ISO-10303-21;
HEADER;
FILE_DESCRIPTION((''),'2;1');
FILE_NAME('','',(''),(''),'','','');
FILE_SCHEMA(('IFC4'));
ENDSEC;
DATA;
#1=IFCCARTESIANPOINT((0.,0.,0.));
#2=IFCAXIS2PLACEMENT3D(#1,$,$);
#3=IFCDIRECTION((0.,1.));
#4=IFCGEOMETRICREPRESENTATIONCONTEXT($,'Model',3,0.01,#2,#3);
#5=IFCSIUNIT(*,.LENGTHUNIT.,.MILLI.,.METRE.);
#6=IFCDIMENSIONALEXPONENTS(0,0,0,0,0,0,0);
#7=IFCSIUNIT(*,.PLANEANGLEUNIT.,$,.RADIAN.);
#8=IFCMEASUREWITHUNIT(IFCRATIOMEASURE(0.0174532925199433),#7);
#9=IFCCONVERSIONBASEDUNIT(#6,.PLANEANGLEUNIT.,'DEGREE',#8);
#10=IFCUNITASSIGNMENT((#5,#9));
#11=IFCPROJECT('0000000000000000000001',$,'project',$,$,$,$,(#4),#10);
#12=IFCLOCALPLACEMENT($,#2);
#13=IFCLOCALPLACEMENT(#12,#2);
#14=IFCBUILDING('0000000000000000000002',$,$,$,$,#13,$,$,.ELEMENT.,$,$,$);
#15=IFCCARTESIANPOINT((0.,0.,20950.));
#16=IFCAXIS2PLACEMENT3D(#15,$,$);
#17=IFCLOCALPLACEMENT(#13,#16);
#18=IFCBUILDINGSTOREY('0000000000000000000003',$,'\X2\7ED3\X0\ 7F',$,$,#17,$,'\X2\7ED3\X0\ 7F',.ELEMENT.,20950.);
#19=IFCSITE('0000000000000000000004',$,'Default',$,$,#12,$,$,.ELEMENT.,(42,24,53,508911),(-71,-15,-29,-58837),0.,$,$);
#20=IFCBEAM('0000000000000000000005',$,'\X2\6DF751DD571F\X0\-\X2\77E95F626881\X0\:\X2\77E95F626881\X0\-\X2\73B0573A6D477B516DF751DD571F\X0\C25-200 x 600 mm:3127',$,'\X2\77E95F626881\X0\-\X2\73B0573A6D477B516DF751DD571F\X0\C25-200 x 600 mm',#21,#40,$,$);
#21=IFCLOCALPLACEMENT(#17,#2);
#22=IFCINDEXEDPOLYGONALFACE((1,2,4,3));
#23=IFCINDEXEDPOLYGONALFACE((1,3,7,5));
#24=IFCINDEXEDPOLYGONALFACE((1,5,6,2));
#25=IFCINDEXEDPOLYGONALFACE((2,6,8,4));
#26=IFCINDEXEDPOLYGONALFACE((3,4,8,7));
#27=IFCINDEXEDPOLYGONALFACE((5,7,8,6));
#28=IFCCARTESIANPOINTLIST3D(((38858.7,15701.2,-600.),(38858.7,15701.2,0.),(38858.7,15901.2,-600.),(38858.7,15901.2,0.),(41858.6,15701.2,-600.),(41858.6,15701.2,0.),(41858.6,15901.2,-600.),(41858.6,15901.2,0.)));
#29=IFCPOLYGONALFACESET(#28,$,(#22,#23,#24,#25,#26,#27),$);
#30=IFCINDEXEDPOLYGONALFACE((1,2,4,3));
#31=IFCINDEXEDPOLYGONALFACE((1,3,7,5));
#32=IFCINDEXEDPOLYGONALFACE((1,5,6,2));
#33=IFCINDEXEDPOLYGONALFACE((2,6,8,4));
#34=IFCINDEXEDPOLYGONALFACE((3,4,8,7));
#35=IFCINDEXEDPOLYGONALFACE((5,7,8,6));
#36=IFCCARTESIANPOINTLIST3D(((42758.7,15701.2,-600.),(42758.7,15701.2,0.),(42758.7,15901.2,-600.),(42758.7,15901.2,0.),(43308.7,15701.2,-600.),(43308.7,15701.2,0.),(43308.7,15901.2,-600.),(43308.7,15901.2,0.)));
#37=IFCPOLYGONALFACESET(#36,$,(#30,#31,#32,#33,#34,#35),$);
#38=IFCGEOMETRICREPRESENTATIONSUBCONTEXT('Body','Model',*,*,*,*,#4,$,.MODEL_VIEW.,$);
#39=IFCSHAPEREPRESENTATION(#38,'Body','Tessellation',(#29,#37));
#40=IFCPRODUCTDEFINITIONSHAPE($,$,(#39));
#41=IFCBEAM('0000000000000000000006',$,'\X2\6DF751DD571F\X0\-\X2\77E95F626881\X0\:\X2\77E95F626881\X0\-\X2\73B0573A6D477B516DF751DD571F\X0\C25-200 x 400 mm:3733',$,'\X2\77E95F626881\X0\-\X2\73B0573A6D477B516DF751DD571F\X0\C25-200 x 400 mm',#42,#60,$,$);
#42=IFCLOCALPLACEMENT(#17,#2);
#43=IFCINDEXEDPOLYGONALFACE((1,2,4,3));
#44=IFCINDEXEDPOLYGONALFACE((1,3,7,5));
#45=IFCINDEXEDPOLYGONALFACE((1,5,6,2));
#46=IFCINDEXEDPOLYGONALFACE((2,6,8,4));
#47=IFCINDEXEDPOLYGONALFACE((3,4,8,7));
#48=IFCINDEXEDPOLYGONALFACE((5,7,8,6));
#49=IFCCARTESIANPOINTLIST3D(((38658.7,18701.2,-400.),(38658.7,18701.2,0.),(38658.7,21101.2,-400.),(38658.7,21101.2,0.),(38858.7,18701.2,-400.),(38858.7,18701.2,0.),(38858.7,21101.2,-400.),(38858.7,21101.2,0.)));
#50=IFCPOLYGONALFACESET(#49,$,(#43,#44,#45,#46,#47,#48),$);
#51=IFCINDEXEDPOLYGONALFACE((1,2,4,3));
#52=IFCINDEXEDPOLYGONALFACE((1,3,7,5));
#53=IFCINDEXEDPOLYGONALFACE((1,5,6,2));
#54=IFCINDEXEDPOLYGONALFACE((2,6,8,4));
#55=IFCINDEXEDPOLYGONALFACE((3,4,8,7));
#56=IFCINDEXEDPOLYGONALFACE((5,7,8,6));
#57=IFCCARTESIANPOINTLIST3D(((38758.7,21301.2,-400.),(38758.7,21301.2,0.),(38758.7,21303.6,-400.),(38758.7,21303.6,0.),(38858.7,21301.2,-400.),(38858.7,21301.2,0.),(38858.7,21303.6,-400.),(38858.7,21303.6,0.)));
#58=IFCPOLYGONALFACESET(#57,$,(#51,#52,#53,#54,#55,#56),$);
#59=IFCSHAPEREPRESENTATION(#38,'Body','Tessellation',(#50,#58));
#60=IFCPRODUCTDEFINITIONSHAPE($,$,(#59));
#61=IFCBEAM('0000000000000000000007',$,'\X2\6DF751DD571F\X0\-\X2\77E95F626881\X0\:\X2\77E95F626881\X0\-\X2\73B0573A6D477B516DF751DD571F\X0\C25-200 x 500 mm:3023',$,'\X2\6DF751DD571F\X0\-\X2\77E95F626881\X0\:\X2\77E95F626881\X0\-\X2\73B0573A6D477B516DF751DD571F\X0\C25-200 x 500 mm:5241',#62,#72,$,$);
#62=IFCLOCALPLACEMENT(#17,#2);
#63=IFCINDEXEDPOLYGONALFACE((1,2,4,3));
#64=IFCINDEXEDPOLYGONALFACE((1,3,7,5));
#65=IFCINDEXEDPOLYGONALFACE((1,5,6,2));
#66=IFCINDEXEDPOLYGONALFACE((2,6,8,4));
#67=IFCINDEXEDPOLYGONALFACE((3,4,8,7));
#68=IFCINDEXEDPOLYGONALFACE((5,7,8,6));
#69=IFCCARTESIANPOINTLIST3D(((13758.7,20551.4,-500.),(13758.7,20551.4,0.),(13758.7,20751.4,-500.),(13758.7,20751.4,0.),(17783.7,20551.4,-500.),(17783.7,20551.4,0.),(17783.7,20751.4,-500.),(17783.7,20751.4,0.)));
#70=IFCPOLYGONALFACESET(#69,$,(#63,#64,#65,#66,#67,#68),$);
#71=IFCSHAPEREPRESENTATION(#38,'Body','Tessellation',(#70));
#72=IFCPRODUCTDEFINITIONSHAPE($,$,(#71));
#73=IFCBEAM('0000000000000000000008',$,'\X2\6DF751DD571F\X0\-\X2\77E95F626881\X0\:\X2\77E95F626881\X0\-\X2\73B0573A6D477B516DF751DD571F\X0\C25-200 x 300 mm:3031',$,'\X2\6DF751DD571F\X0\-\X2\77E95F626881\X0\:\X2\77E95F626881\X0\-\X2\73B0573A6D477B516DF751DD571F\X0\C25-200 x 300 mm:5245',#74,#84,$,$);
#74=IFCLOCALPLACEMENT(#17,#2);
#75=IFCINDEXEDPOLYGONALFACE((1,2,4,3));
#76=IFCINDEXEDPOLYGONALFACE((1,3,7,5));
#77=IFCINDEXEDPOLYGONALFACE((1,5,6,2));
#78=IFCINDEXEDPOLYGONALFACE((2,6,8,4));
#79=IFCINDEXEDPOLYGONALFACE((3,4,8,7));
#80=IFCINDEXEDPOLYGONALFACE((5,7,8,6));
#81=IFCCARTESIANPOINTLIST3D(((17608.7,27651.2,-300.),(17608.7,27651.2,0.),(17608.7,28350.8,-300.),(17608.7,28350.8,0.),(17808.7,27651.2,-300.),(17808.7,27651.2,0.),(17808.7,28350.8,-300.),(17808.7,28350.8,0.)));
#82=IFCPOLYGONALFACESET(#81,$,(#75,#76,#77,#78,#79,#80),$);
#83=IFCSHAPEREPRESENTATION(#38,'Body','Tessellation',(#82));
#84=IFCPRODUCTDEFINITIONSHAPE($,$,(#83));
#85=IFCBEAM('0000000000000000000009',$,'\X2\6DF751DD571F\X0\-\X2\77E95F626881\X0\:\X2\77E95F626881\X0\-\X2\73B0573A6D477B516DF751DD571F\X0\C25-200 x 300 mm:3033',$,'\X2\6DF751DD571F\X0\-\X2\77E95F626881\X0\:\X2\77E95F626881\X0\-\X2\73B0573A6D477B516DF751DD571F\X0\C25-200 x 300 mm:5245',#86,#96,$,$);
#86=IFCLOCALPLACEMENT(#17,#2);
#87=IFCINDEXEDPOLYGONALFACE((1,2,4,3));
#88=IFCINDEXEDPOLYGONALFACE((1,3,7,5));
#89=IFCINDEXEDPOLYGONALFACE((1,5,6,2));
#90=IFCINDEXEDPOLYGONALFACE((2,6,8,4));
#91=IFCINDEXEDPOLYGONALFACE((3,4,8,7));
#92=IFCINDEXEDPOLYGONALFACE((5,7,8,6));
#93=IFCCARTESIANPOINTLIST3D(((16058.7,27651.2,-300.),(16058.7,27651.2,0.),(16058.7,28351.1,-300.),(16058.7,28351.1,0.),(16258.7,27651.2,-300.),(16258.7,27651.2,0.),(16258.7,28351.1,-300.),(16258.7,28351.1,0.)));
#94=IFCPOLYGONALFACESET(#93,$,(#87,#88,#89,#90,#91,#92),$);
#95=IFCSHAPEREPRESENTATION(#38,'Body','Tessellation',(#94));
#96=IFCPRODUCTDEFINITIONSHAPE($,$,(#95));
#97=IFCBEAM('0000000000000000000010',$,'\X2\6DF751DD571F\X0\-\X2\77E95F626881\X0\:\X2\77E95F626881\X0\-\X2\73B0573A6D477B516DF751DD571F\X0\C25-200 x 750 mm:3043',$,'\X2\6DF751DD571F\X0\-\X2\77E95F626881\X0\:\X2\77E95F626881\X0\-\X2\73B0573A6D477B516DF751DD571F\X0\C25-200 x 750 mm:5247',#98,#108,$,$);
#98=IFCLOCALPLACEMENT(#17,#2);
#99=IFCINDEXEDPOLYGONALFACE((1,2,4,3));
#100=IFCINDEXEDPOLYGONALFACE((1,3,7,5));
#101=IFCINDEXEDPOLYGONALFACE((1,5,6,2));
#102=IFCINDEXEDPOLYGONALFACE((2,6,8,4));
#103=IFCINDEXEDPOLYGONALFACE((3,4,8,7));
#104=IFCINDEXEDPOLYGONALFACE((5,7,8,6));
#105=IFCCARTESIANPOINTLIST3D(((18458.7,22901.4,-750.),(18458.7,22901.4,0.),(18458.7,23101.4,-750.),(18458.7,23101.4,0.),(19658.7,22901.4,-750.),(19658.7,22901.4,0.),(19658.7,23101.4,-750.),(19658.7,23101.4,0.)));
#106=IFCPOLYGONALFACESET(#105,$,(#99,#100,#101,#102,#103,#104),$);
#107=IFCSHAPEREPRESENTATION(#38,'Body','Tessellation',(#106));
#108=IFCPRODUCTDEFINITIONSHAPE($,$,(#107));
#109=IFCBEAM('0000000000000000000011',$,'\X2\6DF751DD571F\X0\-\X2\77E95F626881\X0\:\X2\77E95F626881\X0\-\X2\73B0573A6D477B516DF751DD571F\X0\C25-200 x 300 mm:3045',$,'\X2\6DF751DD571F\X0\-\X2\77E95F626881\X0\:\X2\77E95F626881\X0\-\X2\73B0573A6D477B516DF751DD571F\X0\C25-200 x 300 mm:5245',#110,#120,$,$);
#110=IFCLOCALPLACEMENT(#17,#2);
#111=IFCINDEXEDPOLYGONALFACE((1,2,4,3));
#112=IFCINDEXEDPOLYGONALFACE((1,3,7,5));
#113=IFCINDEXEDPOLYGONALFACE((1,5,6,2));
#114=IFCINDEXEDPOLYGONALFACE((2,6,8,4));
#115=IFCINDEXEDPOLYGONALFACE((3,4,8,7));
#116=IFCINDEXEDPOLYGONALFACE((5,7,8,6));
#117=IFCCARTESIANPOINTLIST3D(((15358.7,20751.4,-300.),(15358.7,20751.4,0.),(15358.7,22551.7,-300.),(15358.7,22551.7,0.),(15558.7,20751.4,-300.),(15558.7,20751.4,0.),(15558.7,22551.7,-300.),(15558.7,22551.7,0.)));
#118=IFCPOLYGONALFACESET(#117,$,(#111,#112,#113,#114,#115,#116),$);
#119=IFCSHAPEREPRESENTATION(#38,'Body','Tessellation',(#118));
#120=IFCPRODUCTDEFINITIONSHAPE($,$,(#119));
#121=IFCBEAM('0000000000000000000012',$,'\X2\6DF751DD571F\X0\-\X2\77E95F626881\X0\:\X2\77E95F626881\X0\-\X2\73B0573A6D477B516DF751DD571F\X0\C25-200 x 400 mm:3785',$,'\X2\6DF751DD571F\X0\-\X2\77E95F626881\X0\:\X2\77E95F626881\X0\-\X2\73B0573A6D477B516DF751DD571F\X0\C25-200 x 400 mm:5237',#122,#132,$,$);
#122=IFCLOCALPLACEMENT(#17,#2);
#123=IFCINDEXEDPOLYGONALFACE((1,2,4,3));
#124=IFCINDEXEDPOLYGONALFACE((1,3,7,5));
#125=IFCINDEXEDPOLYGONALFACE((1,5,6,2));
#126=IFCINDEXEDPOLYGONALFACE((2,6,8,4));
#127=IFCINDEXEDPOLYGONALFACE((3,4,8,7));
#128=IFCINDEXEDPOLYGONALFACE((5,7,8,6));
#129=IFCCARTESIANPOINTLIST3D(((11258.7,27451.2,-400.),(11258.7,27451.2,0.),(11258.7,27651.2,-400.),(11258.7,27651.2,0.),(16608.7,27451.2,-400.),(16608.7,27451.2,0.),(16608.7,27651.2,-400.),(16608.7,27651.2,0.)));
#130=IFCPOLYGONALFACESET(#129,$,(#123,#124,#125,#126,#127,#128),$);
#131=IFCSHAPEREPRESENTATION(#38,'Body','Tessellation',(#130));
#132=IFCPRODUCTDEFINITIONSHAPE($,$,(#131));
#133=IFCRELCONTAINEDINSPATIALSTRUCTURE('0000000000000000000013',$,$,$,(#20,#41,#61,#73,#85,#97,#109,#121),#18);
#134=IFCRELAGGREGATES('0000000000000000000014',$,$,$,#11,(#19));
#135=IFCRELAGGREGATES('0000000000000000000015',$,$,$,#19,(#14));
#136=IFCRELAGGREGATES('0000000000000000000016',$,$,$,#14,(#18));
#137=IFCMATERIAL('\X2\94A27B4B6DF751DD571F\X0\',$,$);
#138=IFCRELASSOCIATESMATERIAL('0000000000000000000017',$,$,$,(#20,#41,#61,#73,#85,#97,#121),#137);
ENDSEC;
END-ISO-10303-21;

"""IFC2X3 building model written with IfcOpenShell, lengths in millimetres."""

from ifc_helpers import new_model, entity, si_unit, converted_unit, direction, frame, frame_2d, origin, origin_2d_with_axis, place, context, subcontext, project, spatial, rectangle, extrude, source, transform, mapped, material, element, save


model = new_model("IFC2X3")

# Units and contexts
model_context = context("Model", 3, precision=0.01, world=origin(), true_north=direction((0.0, 1.0)))
body_context = subcontext(model_context, "Body", "Model", "MODEL_VIEW")
ifc_project = project(units=[si_unit("LENGTHUNIT", "METRE", prefix="MILLI"), converted_unit("PLANEANGLEUNIT", "DEGREE", entity("IfcRatioMeasure", 0.0174532925199433), si_unit("PLANEANGLEUNIT", "RADIAN"), dimensions=[0, 0, 0, 0, 0, 0, 0])], contexts=[model_context])

# Site, building, storey
site_placement = place(None, origin())
site = spatial("IfcSite", under=ifc_project, at=site_placement, Name="Default", CompositionType="ELEMENT", RefLatitude=(42, 24, 53, 508911), RefLongitude=(-71, -15, -29, -58837), RefElevation=0.0)
building_placement = place(site_placement, origin())
building = spatial("IfcBuilding", under=site, at=building_placement, CompositionType="ELEMENT")
storey_placement = place(building_placement, frame((0.0, 0.0, 20950.0)))
storey = spatial("IfcBuildingStorey", under=building, at=storey_placement, Name="结 7F", LongName="结 7F", CompositionType="ELEMENT", Elevation=20950.0)

# Beams
ifc_material = material(Name="钢筋混凝土")
shared_shape_1 = source(origin(), body_context, "Body", "SweptSolid", [
    extrude(rectangle(XDim=2999.9, YDim=200.0, at=frame_2d((0.0, 0.0), x_axis=(1.0, 0.0))), frame((40358.6, 15801.2, 20350.0)), (0.0, 0.0, 1.0), 600.0),
    extrude(rectangle(XDim=550.1, YDim=200.0, at=origin_2d_with_axis()), frame((43033.7, 15801.2, 20350.0), z_axis=(0.0, 0.0, 1.0), x_axis=(-1.0, 0.0, 0.0)), (0.0, 0.0, 1.0), 600.0),
])
beam_1_placement = place(storey_placement, frame((0.0, 0.0, -20950.0)))
element("IfcBeam", 1, at=beam_1_placement, inside=storey, material=ifc_material, Name="混凝土-矩形梁:矩形梁-现场浇筑混凝土C25-200 x 600 mm:3127", ObjectType="矩形梁-现场浇筑混凝土C25-200 x 600 mm", context=body_context, shape_type="MappedRepresentation", body=[
    mapped(shared_shape_1, transform((0.0, 0.0, 0.0), scale=1.0)),
])
shared_shape_2 = source(origin(), body_context, "Body", "SweptSolid", [
    extrude(rectangle(XDim=2400.0, YDim=200.0, at=frame_2d((0.0, 0.0), x_axis=(1.0, 0.0))), frame((38758.7, 19901.2, 20550.0), z_axis=(0.0, 0.0, 1.0), x_axis=(0.0, -1.0, 0.0)), (0.0, 0.0, 1.0), 400.0),
    extrude(rectangle(XDim=2.4, YDim=100.0, at=frame_2d((0.0, 0.0), x_axis=(1.0, 0.0))), frame((38808.7, 21302.4, 20550.0), z_axis=(0.0, 0.0, 1.0), x_axis=(0.0, -1.0, 0.0)), (0.0, 0.0, 1.0), 400.0),
])
beam_2_placement = place(storey_placement, frame((0.0, 0.0, -20950.0)))
element("IfcBeam", 2, at=beam_2_placement, inside=storey, material=ifc_material, Name="混凝土-矩形梁:矩形梁-现场浇筑混凝土C25-200 x 400 mm:3733", ObjectType="矩形梁-现场浇筑混凝土C25-200 x 400 mm", context=body_context, shape_type="MappedRepresentation", body=[
    mapped(shared_shape_2, transform((0.0, 0.0, 0.0), scale=1.0)),
])
beam_3_placement = place(storey_placement, frame((13658.7, 20651.4, 0.0)))
element("IfcBeam", 3, at=beam_3_placement, inside=storey, material=ifc_material, Name="混凝土-矩形梁:矩形梁-现场浇筑混凝土C25-200 x 500 mm:3023", ObjectType="混凝土-矩形梁:矩形梁-现场浇筑混凝土C25-200 x 500 mm:5241", context=body_context, shape_type="SweptSolid", body=[
    extrude(rectangle(XDim=500.0, YDim=200.0, at=frame_2d((0.0, 0.0), x_axis=(1.0, 0.0))), frame((100.0, 0.0, -250.0), z_axis=(1.0, 0.0, 0.0), x_axis=(0.0, 0.0, -1.0)), (0.0, 0.0, 1.0), 4025.0),
])
beam_4_placement = place(storey_placement, frame((17708.7, 27551.2, 0.0), z_axis=(0.0, 0.0, 1.0), x_axis=(0.0, 1.0, 0.0)))
element("IfcBeam", 4, at=beam_4_placement, inside=storey, material=ifc_material, Name="混凝土-矩形梁:矩形梁-现场浇筑混凝土C25-200 x 300 mm:3031", ObjectType="混凝土-矩形梁:矩形梁-现场浇筑混凝土C25-200 x 300 mm:5245", context=body_context, shape_type="SweptSolid", body=[
    extrude(rectangle(XDim=300.0, YDim=200.0, at=frame_2d((0.0, 0.0), x_axis=(1.0, 0.0))), frame((100.0, 0.0, -150.0), z_axis=(1.0, 0.0, 0.0), x_axis=(0.0, 0.0, -1.0)), (0.0, 0.0, 1.0), 699.6),
])
beam_5_placement = place(storey_placement, frame((16158.7, 27551.2, 0.0), z_axis=(0.0, 0.0, 1.0), x_axis=(0.0, 1.0, 0.0)))
element("IfcBeam", 5, at=beam_5_placement, inside=storey, material=ifc_material, Name="混凝土-矩形梁:矩形梁-现场浇筑混凝土C25-200 x 300 mm:3033", ObjectType="混凝土-矩形梁:矩形梁-现场浇筑混凝土C25-200 x 300 mm:5245", context=body_context, shape_type="SweptSolid", body=[
    extrude(rectangle(XDim=300.0, YDim=200.0, at=frame_2d((0.0, 0.0), x_axis=(1.0, 0.0))), frame((100.0, 0.0, -150.0), z_axis=(1.0, 0.0, 0.0), x_axis=(0.0, 0.0, -1.0)), (0.0, 0.0, 1.0), 699.9),
])
beam_6_placement = place(storey_placement, frame((17708.7, 23001.4, 0.0)))
element("IfcBeam", 6, at=beam_6_placement, inside=storey, material=ifc_material, Name="混凝土-矩形梁:矩形梁-现场浇筑混凝土C25-200 x 750 mm:3043", ObjectType="混凝土-矩形梁:矩形梁-现场浇筑混凝土C25-200 x 750 mm:5247", context=body_context, shape_type="SweptSolid", body=[
    extrude(rectangle(XDim=750.0, YDim=200.0, at=frame_2d((0.0, 0.0), x_axis=(1.0, 0.0))), frame((750.0, 0.0, -375.0), z_axis=(1.0, 0.0, 0.0), x_axis=(0.0, 0.0, -1.0)), (0.0, 0.0, 1.0), 1200.0),
])
beam_7_placement = place(storey_placement, frame((15458.7, 20651.4, 0.0), z_axis=(0.0, 0.0, 1.0), x_axis=(0.0, 1.0, 0.0)))
element("IfcBeam", 7, at=beam_7_placement, inside=storey, Name="混凝土-矩形梁:矩形梁-现场浇筑混凝土C25-200 x 300 mm:3045", ObjectType="混凝土-矩形梁:矩形梁-现场浇筑混凝土C25-200 x 300 mm:5245", context=body_context, shape_type="SweptSolid", body=[
    extrude(rectangle(XDim=300.0, YDim=200.0, at=frame_2d((0.0, 0.0), x_axis=(1.0, 0.0))), frame((100.0, 0.0, -150.0), z_axis=(1.0, 0.0, 0.0), x_axis=(0.0, 0.0, -1.0)), (0.0, 0.0, 1.0), 1800.3),
])
beam_8_placement = place(storey_placement, frame((11158.7, 27551.2, 0.0)))
element("IfcBeam", 8, at=beam_8_placement, inside=storey, material=ifc_material, Name="混凝土-矩形梁:矩形梁-现场浇筑混凝土C25-200 x 400 mm:3785", ObjectType="混凝土-矩形梁:矩形梁-现场浇筑混凝土C25-200 x 400 mm:5237", context=body_context, shape_type="SweptSolid", body=[
    extrude(rectangle(XDim=400.0, YDim=200.0, at=frame_2d((0.0, 0.0), x_axis=(1.0, 0.0))), frame((100.0, 0.0, -200.0), z_axis=(1.0, 0.0, 0.0), x_axis=(0.0, 0.0, -1.0)), (0.0, 0.0, 1.0), 5350.0),
])

save(model, "model.ifc")
